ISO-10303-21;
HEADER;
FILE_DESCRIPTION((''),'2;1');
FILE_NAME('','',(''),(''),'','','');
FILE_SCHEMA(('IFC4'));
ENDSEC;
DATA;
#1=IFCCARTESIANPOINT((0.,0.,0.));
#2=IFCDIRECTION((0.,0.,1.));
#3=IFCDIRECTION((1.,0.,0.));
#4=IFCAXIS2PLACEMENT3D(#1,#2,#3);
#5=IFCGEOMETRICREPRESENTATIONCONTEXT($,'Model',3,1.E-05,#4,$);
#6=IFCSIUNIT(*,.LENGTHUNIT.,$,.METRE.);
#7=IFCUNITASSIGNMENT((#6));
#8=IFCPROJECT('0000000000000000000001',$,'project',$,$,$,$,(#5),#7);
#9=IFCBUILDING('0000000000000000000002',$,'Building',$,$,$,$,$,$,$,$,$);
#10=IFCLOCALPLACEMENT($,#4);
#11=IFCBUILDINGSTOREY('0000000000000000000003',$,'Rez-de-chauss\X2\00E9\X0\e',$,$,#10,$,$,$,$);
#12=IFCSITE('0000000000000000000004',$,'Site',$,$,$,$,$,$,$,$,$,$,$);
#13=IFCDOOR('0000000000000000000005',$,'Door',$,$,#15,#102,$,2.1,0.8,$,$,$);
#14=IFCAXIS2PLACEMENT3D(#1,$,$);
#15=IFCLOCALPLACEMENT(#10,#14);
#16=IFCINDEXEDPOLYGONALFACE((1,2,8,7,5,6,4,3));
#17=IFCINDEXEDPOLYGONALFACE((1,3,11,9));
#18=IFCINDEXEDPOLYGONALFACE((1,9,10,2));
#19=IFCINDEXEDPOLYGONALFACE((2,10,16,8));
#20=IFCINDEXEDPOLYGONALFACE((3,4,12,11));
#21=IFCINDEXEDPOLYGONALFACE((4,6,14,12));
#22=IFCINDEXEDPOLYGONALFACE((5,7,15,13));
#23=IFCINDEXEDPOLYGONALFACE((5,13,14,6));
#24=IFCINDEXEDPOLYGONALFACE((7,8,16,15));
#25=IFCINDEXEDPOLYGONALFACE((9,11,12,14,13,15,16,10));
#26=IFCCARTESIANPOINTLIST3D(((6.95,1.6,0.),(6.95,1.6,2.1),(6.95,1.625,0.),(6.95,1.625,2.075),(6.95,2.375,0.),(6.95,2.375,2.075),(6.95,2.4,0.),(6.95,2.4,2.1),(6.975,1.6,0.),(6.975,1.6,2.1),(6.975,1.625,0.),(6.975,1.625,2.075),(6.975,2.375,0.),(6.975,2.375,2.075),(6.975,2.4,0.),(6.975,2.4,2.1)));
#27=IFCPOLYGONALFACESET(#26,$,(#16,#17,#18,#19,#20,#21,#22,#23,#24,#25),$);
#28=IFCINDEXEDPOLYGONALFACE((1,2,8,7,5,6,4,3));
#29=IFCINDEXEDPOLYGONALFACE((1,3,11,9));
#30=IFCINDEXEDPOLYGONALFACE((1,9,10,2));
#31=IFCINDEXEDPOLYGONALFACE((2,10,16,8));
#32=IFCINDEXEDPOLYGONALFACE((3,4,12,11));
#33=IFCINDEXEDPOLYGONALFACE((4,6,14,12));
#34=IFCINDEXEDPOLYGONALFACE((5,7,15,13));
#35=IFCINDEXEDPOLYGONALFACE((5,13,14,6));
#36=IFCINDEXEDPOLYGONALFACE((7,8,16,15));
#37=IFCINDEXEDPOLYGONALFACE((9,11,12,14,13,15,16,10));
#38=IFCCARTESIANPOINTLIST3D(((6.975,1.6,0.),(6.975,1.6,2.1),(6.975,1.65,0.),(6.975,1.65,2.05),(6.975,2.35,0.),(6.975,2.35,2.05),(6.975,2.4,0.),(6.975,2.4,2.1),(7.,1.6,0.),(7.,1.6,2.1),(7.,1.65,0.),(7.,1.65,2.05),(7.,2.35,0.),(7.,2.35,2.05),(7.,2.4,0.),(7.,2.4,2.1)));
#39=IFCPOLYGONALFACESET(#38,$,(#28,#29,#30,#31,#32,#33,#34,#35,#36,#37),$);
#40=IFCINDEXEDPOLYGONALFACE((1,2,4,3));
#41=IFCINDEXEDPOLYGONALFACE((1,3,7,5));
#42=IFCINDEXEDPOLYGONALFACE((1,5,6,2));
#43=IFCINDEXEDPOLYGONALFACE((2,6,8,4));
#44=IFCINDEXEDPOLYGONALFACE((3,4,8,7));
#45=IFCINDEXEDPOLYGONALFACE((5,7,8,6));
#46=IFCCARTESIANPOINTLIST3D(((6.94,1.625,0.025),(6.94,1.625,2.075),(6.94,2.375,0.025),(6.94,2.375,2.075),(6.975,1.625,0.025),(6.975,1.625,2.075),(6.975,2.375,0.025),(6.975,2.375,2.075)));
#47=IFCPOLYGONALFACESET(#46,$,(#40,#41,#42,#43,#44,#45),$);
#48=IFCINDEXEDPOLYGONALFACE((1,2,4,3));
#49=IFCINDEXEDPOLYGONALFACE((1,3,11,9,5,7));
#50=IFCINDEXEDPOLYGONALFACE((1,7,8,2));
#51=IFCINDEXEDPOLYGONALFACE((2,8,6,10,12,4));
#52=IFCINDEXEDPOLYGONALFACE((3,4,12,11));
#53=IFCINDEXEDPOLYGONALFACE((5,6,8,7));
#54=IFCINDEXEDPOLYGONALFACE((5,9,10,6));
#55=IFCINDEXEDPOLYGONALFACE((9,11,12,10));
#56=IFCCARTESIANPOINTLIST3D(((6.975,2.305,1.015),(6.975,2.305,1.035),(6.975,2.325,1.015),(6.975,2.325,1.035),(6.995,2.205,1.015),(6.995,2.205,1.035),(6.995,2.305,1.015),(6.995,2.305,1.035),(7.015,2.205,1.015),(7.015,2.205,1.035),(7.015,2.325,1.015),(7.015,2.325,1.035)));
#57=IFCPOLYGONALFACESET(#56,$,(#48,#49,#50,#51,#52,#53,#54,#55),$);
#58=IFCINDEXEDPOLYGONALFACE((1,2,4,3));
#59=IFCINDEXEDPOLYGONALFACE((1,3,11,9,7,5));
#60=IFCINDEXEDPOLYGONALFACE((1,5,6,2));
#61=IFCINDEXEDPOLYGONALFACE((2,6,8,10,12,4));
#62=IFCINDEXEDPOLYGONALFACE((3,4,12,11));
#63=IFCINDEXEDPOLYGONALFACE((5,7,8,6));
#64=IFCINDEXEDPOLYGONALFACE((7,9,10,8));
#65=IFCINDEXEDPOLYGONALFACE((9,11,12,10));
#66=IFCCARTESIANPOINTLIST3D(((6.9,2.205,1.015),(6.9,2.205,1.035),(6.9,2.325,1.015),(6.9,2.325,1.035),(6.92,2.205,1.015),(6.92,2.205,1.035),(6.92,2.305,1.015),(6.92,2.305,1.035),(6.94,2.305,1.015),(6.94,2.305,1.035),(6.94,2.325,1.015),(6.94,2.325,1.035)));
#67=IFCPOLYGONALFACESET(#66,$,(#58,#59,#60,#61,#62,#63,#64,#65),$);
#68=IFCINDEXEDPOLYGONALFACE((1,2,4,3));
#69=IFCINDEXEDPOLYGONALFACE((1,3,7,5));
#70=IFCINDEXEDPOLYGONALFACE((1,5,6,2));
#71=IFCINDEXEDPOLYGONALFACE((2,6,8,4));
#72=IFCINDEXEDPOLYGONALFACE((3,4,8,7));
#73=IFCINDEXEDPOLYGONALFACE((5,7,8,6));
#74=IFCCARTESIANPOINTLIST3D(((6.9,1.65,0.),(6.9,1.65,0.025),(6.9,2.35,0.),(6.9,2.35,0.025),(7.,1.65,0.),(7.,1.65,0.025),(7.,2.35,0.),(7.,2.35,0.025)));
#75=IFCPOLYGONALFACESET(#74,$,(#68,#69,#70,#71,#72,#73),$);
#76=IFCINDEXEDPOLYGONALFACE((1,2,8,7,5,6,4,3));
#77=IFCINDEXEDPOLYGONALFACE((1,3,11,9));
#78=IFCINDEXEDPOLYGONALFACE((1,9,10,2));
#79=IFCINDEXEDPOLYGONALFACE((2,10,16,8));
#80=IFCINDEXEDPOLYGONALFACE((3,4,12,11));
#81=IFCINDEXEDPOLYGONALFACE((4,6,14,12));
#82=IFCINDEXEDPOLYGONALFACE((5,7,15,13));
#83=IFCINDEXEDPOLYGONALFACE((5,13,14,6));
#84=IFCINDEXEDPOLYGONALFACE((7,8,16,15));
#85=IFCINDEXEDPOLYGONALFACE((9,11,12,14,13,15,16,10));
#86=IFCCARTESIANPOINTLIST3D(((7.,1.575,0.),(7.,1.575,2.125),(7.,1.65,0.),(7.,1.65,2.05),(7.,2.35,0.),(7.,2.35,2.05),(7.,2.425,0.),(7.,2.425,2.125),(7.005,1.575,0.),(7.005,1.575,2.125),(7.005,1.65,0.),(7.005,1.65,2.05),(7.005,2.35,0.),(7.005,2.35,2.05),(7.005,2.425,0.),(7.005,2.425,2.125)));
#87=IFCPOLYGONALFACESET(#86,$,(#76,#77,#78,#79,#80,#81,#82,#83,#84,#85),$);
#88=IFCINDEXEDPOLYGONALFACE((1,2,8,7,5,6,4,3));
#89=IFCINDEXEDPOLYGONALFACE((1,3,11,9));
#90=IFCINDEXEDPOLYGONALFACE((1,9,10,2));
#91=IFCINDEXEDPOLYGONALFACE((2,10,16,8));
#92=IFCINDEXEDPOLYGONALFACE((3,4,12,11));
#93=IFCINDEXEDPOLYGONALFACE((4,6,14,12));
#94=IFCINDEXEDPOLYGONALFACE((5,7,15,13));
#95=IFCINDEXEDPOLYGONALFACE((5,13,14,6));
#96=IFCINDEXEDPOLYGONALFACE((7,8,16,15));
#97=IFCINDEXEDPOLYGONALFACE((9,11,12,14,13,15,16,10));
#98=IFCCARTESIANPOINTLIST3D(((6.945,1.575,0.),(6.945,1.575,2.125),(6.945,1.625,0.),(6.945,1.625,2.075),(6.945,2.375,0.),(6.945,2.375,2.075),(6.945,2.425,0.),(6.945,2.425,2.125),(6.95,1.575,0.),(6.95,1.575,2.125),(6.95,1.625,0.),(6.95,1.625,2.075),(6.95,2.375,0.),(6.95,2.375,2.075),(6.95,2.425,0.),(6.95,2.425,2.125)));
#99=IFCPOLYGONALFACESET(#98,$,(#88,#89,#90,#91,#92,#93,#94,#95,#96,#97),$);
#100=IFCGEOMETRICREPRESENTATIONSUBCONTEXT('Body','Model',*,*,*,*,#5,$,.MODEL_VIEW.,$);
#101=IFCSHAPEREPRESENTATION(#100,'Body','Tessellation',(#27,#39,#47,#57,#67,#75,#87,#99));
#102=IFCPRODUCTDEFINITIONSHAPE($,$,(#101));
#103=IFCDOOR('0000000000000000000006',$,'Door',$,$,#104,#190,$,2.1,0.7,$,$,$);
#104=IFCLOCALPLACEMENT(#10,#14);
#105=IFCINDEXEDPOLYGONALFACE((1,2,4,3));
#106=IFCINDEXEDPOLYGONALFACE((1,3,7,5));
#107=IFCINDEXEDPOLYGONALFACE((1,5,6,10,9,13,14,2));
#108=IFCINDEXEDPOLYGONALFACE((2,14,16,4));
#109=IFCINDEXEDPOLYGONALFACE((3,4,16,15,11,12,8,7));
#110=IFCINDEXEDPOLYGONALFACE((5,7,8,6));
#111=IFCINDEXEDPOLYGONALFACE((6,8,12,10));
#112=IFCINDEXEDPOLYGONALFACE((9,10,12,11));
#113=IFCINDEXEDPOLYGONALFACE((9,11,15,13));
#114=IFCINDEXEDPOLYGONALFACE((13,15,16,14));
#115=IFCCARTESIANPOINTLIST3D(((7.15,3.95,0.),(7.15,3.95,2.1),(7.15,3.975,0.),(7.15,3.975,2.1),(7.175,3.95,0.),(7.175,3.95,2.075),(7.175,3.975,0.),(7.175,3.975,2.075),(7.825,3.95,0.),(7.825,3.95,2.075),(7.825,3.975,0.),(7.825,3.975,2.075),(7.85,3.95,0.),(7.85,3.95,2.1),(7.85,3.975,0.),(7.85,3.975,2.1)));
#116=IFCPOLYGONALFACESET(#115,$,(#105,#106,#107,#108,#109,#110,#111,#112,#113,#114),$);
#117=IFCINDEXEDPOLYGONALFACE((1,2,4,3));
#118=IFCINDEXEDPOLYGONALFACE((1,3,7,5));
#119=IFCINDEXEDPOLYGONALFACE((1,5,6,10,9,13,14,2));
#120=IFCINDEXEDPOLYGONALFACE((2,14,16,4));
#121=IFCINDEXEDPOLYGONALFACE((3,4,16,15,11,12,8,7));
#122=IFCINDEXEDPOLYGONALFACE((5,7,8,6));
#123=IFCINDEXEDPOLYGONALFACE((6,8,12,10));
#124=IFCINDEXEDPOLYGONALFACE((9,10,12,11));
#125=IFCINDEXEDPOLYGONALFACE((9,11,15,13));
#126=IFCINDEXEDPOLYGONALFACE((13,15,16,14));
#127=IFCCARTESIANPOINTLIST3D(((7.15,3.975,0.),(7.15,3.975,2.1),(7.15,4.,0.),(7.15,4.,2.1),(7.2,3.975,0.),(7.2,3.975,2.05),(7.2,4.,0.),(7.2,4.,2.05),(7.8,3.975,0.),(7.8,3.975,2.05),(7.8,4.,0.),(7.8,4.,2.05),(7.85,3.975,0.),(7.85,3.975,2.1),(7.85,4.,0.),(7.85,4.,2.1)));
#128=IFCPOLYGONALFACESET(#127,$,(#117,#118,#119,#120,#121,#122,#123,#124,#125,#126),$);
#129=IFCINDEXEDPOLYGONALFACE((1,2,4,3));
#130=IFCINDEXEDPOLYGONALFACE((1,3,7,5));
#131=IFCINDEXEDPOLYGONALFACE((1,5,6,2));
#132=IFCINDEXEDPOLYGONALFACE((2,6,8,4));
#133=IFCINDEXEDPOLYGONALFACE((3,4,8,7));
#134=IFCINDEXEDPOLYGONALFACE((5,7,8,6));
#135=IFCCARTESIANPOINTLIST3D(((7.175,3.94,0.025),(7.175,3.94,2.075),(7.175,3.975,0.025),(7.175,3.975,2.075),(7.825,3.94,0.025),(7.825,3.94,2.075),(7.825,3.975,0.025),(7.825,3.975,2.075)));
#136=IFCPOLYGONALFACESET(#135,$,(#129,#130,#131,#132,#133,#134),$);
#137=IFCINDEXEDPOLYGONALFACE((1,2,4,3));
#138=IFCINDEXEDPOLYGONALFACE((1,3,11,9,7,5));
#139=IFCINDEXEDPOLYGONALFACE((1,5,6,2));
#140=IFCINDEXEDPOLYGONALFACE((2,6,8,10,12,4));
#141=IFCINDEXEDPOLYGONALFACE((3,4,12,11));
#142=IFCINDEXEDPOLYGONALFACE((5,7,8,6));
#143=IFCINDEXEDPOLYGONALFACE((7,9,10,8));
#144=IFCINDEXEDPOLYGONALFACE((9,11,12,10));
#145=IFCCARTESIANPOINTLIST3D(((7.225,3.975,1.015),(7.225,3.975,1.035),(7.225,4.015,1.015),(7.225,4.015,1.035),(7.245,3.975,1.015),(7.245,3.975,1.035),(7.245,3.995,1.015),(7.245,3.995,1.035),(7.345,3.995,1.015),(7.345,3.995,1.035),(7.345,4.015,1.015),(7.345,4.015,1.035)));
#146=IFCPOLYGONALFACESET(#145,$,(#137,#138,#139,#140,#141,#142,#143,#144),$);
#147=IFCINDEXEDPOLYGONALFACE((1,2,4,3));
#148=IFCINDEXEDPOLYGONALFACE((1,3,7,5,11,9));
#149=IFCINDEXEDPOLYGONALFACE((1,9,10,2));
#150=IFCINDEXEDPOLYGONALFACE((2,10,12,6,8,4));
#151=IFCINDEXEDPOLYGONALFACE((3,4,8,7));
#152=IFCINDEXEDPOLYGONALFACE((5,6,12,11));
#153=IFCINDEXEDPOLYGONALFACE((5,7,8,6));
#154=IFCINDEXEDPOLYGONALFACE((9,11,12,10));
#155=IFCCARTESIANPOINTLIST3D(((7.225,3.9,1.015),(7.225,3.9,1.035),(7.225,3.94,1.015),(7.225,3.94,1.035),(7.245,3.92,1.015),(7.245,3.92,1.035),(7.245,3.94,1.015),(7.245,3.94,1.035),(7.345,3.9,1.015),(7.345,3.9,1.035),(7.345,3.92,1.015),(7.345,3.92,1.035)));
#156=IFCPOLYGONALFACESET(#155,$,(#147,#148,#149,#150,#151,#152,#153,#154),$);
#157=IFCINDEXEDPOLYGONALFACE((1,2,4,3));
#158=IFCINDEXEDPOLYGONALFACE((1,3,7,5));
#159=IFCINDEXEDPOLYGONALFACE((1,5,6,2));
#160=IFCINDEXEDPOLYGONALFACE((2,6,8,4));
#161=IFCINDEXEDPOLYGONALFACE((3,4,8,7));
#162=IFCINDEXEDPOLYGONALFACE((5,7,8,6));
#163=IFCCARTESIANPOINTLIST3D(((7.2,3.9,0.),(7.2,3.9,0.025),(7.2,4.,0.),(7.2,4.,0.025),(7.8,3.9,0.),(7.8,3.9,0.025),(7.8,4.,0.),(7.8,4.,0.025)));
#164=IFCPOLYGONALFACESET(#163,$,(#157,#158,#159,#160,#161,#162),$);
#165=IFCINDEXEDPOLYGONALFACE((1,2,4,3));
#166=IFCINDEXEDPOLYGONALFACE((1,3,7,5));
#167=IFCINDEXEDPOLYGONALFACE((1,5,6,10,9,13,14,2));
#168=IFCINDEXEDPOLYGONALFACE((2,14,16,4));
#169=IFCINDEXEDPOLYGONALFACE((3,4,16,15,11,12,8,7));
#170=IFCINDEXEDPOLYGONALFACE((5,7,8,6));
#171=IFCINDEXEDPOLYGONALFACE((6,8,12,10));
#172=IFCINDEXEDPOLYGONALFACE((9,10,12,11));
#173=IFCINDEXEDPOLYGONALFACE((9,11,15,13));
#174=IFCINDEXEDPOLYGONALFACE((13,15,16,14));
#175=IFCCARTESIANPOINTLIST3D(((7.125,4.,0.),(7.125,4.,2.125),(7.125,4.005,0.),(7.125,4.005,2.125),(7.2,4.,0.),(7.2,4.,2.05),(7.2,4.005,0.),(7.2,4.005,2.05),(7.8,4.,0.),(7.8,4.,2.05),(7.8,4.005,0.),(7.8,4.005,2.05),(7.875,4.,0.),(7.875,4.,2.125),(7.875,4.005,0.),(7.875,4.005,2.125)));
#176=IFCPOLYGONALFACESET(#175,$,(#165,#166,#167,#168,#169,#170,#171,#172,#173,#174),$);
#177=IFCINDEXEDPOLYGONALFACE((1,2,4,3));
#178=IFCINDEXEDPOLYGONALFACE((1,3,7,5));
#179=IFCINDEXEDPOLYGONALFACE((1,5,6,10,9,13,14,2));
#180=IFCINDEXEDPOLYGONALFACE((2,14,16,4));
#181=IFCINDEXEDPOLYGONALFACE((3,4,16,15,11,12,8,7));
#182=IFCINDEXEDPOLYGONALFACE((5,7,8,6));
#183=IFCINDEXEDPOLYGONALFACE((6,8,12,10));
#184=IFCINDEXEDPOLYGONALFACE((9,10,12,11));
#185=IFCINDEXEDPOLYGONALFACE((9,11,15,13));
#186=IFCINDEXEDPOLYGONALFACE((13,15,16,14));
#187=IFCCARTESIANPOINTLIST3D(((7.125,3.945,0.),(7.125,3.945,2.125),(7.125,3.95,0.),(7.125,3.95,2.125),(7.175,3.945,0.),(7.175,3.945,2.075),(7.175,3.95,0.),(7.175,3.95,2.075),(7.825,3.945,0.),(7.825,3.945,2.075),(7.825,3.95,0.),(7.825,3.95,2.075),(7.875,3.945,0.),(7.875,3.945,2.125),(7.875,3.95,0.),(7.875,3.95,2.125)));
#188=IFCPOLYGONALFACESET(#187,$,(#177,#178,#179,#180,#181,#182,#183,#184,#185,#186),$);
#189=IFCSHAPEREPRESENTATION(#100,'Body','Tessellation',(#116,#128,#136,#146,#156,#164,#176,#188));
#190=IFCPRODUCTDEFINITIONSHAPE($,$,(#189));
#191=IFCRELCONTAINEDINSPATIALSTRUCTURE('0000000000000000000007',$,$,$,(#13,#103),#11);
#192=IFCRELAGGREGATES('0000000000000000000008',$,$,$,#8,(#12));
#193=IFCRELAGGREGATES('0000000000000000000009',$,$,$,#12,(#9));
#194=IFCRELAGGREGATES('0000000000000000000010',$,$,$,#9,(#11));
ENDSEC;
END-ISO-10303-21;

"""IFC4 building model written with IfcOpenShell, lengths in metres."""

from ifc_helpers import new_model, si_unit, frame, origin_with_axes, place, context, subcontext, project, spatial, line, indexed_curve, outline, extrude, element, save


model = new_model("IFC4")

# Units and contexts
model_context = context("Model", 3, precision=1e-05, world=origin_with_axes())
body_context = subcontext(model_context, "Body", "Model", "MODEL_VIEW")
ifc_project = project(units=[si_unit("LENGTHUNIT", "METRE")], contexts=[model_context])

# Site, building, storey
site = spatial("IfcSite", under=ifc_project, Name="Site")
building = spatial("IfcBuilding", under=site, Name="Building")
storey_placement = place(None, origin_with_axes())
storey = spatial("IfcBuildingStorey", under=building, at=storey_placement, Name="Rez-de-chaussée")

# Doors
door_1_placement = place(storey_placement, frame((7.0, 1.6, 0.0), z_axis=(0.0, 0.0, 1.0), x_axis=(0.0, 1.0, 0.0)))
element("IfcDoor", 1, at=door_1_placement, inside=storey, Name="Door", OverallHeight=2.1, OverallWidth=0.8, context=body_context, shape_type="SweptSolid", body=[
    extrude(outline(indexed_curve([(0.0, 0.0), (0.0, 2.1), (0.8, 2.1), (0.8, 0.0), (0.775, 0.0), (0.775, 2.075), (0.025, 2.075), (0.025, 0.0)], segments=[line(1, 2, 3, 4, 5, 6, 7, 8, 1)])), frame((0.0, 0.025, 0.0), z_axis=(0.0, -1.0, 0.0), x_axis=(1.0, 0.0, 0.0)), (0.0, 0.0, -1.0), 0.025),
    extrude(outline(indexed_curve([(0.0, 0.0), (0.0, 2.1), (0.8, 2.1), (0.8, 0.0), (0.75, 0.0), (0.75, 2.05), (0.05, 2.05), (0.05, 0.0)], segments=[line(1, 2, 3, 4, 5, 6, 7, 8, 1)])), frame((0.0, 0.0, 0.0), z_axis=(0.0, -1.0, 0.0), x_axis=(1.0, 0.0, 0.0)), (0.0, 0.0, -1.0), 0.025),
    extrude(outline(indexed_curve([(0.0, 0.0), (0.75, 0.0), (0.75, 0.035), (0.0, 0.035)], segments=[line(1, 2, 3, 4, 1)])), frame((0.025, 0.025, 0.025), z_axis=(0.0, 0.0, 1.0), x_axis=(1.0, 0.0, 0.0)), (0.0, 0.0, 1.0), 2.05),
    extrude(outline(indexed_curve([(0.0, 0.0), (0.0, -0.04), (-0.12, -0.04), (-0.12, -0.02), (-0.02, -0.02), (-0.02, 0.0)], segments=[line(1, 2, 3, 4, 5, 6, 1)])), frame((0.725, 0.025, 1.015), z_axis=(0.0, 0.0, 1.0), x_axis=(1.0, 0.0, 0.0)), (0.0, 0.0, 1.0), 0.02),
    extrude(outline(indexed_curve([(0.0, 0.0), (0.0, 0.04), (-0.12, 0.04), (-0.12, 0.02), (-0.02, 0.02), (-0.02, 0.0)], segments=[line(1, 2, 3, 4, 5, 6, 1)])), frame((0.725, 0.06, 1.015), z_axis=(0.0, 0.0, 1.0), x_axis=(1.0, 0.0, 0.0)), (0.0, 0.0, 1.0), 0.02),
    extrude(outline(indexed_curve([(0.0, 0.0), (0.7, 0.0), (0.7, 0.1), (0.0, 0.1)], segments=[line(1, 2, 3, 4, 1)])), frame((0.05, 0.0, 0.0), z_axis=(0.0, 0.0, 1.0), x_axis=(1.0, 0.0, 0.0)), (0.0, 0.0, 1.0), 0.025),
    extrude(outline(indexed_curve([(0.0, 0.0), (0.0, 2.125), (0.85, 2.125), (0.85, 0.0), (0.775, 0.0), (0.775, 2.05), (0.075, 2.05), (0.075, 0.0)], segments=[line(1, 2, 3, 4, 5, 6, 7, 8, 1)])), frame((-0.025, -0.005, 0.0), z_axis=(0.0, -1.0, 0.0), x_axis=(1.0, 0.0, 0.0)), (0.0, 0.0, -1.0), 0.005),
    extrude(outline(indexed_curve([(0.0, 0.0), (0.0, 2.125), (0.85, 2.125), (0.85, 0.0), (0.8, 0.0), (0.8, 2.075), (0.05, 2.075), (0.05, 0.0)], segments=[line(1, 2, 3, 4, 5, 6, 7, 8, 1)])), frame((-0.025, 0.05, 0.0), z_axis=(0.0, -1.0, 0.0), x_axis=(1.0, 0.0, 0.0)), (0.0, 0.0, -1.0), 0.005),
])
door_2_placement = place(storey_placement, frame((7.85, 4.0, 0.0), z_axis=(0.0, 0.0, 1.0), x_axis=(-1.0, 0.0, 0.0)))
element("IfcDoor", 2, at=door_2_placement, inside=storey, Name="Door", OverallHeight=2.1, OverallWidth=0.7, context=body_context, shape_type="SweptSolid", body=[
    extrude(outline(indexed_curve([(0.0, 0.0), (0.0, 2.1), (0.7, 2.1), (0.7, 0.0), (0.675, 0.0), (0.675, 2.075), (0.025, 2.075), (0.025, 0.0)], segments=[line(1, 2, 3, 4, 5, 6, 7, 8, 1)])), frame((0.0, 0.025, 0.0), z_axis=(0.0, -1.0, 0.0), x_axis=(1.0, 0.0, 0.0)), (0.0, 0.0, -1.0), 0.025),
    extrude(outline(indexed_curve([(0.0, 0.0), (0.0, 2.1), (0.7, 2.1), (0.7, 0.0), (0.65, 0.0), (0.65, 2.05), (0.05, 2.05), (0.05, 0.0)], segments=[line(1, 2, 3, 4, 5, 6, 7, 8, 1)])), frame((0.0, 0.0, 0.0), z_axis=(0.0, -1.0, 0.0), x_axis=(1.0, 0.0, 0.0)), (0.0, 0.0, -1.0), 0.025),
    extrude(outline(indexed_curve([(0.0, 0.0), (0.65, 0.0), (0.65, 0.035), (0.0, 0.035)], segments=[line(1, 2, 3, 4, 1)])), frame((0.025, 0.025, 0.025), z_axis=(0.0, 0.0, 1.0), x_axis=(1.0, 0.0, 0.0)), (0.0, 0.0, 1.0), 2.05),
    extrude(outline(indexed_curve([(0.0, 0.0), (0.0, -0.04), (-0.12, -0.04), (-0.12, -0.02), (-0.02, -0.02), (-0.02, 0.0)], segments=[line(1, 2, 3, 4, 5, 6, 1)])), frame((0.625, 0.025, 1.015), z_axis=(0.0, 0.0, 1.0), x_axis=(1.0, 0.0, 0.0)), (0.0, 0.0, 1.0), 0.02),
    extrude(outline(indexed_curve([(0.0, 0.0), (0.0, 0.04), (-0.12, 0.04), (-0.12, 0.02), (-0.02, 0.02), (-0.02, 0.0)], segments=[line(1, 2, 3, 4, 5, 6, 1)])), frame((0.625, 0.06, 1.015), z_axis=(0.0, 0.0, 1.0), x_axis=(1.0, 0.0, 0.0)), (0.0, 0.0, 1.0), 0.02),
    extrude(outline(indexed_curve([(0.0, 0.0), (0.6, 0.0), (0.6, 0.1), (0.0, 0.1)], segments=[line(1, 2, 3, 4, 1)])), frame((0.05, 0.0, 0.0), z_axis=(0.0, 0.0, 1.0), x_axis=(1.0, 0.0, 0.0)), (0.0, 0.0, 1.0), 0.025),
    extrude(outline(indexed_curve([(0.0, 0.0), (0.0, 2.125), (0.75, 2.125), (0.75, 0.0), (0.675, 0.0), (0.675, 2.05), (0.075, 2.05), (0.075, 0.0)], segments=[line(1, 2, 3, 4, 5, 6, 7, 8, 1)])), frame((-0.025, -0.005, 0.0), z_axis=(0.0, -1.0, 0.0), x_axis=(1.0, 0.0, 0.0)), (0.0, 0.0, -1.0), 0.005),
    extrude(outline(indexed_curve([(0.0, 0.0), (0.0, 2.125), (0.75, 2.125), (0.75, 0.0), (0.7, 0.0), (0.7, 2.075), (0.05, 2.075), (0.05, 0.0)], segments=[line(1, 2, 3, 4, 5, 6, 7, 8, 1)])), frame((-0.025, 0.05, 0.0), z_axis=(0.0, -1.0, 0.0), x_axis=(1.0, 0.0, 0.0)), (0.0, 0.0, -1.0), 0.005),
])

save(model, "model.ifc")
